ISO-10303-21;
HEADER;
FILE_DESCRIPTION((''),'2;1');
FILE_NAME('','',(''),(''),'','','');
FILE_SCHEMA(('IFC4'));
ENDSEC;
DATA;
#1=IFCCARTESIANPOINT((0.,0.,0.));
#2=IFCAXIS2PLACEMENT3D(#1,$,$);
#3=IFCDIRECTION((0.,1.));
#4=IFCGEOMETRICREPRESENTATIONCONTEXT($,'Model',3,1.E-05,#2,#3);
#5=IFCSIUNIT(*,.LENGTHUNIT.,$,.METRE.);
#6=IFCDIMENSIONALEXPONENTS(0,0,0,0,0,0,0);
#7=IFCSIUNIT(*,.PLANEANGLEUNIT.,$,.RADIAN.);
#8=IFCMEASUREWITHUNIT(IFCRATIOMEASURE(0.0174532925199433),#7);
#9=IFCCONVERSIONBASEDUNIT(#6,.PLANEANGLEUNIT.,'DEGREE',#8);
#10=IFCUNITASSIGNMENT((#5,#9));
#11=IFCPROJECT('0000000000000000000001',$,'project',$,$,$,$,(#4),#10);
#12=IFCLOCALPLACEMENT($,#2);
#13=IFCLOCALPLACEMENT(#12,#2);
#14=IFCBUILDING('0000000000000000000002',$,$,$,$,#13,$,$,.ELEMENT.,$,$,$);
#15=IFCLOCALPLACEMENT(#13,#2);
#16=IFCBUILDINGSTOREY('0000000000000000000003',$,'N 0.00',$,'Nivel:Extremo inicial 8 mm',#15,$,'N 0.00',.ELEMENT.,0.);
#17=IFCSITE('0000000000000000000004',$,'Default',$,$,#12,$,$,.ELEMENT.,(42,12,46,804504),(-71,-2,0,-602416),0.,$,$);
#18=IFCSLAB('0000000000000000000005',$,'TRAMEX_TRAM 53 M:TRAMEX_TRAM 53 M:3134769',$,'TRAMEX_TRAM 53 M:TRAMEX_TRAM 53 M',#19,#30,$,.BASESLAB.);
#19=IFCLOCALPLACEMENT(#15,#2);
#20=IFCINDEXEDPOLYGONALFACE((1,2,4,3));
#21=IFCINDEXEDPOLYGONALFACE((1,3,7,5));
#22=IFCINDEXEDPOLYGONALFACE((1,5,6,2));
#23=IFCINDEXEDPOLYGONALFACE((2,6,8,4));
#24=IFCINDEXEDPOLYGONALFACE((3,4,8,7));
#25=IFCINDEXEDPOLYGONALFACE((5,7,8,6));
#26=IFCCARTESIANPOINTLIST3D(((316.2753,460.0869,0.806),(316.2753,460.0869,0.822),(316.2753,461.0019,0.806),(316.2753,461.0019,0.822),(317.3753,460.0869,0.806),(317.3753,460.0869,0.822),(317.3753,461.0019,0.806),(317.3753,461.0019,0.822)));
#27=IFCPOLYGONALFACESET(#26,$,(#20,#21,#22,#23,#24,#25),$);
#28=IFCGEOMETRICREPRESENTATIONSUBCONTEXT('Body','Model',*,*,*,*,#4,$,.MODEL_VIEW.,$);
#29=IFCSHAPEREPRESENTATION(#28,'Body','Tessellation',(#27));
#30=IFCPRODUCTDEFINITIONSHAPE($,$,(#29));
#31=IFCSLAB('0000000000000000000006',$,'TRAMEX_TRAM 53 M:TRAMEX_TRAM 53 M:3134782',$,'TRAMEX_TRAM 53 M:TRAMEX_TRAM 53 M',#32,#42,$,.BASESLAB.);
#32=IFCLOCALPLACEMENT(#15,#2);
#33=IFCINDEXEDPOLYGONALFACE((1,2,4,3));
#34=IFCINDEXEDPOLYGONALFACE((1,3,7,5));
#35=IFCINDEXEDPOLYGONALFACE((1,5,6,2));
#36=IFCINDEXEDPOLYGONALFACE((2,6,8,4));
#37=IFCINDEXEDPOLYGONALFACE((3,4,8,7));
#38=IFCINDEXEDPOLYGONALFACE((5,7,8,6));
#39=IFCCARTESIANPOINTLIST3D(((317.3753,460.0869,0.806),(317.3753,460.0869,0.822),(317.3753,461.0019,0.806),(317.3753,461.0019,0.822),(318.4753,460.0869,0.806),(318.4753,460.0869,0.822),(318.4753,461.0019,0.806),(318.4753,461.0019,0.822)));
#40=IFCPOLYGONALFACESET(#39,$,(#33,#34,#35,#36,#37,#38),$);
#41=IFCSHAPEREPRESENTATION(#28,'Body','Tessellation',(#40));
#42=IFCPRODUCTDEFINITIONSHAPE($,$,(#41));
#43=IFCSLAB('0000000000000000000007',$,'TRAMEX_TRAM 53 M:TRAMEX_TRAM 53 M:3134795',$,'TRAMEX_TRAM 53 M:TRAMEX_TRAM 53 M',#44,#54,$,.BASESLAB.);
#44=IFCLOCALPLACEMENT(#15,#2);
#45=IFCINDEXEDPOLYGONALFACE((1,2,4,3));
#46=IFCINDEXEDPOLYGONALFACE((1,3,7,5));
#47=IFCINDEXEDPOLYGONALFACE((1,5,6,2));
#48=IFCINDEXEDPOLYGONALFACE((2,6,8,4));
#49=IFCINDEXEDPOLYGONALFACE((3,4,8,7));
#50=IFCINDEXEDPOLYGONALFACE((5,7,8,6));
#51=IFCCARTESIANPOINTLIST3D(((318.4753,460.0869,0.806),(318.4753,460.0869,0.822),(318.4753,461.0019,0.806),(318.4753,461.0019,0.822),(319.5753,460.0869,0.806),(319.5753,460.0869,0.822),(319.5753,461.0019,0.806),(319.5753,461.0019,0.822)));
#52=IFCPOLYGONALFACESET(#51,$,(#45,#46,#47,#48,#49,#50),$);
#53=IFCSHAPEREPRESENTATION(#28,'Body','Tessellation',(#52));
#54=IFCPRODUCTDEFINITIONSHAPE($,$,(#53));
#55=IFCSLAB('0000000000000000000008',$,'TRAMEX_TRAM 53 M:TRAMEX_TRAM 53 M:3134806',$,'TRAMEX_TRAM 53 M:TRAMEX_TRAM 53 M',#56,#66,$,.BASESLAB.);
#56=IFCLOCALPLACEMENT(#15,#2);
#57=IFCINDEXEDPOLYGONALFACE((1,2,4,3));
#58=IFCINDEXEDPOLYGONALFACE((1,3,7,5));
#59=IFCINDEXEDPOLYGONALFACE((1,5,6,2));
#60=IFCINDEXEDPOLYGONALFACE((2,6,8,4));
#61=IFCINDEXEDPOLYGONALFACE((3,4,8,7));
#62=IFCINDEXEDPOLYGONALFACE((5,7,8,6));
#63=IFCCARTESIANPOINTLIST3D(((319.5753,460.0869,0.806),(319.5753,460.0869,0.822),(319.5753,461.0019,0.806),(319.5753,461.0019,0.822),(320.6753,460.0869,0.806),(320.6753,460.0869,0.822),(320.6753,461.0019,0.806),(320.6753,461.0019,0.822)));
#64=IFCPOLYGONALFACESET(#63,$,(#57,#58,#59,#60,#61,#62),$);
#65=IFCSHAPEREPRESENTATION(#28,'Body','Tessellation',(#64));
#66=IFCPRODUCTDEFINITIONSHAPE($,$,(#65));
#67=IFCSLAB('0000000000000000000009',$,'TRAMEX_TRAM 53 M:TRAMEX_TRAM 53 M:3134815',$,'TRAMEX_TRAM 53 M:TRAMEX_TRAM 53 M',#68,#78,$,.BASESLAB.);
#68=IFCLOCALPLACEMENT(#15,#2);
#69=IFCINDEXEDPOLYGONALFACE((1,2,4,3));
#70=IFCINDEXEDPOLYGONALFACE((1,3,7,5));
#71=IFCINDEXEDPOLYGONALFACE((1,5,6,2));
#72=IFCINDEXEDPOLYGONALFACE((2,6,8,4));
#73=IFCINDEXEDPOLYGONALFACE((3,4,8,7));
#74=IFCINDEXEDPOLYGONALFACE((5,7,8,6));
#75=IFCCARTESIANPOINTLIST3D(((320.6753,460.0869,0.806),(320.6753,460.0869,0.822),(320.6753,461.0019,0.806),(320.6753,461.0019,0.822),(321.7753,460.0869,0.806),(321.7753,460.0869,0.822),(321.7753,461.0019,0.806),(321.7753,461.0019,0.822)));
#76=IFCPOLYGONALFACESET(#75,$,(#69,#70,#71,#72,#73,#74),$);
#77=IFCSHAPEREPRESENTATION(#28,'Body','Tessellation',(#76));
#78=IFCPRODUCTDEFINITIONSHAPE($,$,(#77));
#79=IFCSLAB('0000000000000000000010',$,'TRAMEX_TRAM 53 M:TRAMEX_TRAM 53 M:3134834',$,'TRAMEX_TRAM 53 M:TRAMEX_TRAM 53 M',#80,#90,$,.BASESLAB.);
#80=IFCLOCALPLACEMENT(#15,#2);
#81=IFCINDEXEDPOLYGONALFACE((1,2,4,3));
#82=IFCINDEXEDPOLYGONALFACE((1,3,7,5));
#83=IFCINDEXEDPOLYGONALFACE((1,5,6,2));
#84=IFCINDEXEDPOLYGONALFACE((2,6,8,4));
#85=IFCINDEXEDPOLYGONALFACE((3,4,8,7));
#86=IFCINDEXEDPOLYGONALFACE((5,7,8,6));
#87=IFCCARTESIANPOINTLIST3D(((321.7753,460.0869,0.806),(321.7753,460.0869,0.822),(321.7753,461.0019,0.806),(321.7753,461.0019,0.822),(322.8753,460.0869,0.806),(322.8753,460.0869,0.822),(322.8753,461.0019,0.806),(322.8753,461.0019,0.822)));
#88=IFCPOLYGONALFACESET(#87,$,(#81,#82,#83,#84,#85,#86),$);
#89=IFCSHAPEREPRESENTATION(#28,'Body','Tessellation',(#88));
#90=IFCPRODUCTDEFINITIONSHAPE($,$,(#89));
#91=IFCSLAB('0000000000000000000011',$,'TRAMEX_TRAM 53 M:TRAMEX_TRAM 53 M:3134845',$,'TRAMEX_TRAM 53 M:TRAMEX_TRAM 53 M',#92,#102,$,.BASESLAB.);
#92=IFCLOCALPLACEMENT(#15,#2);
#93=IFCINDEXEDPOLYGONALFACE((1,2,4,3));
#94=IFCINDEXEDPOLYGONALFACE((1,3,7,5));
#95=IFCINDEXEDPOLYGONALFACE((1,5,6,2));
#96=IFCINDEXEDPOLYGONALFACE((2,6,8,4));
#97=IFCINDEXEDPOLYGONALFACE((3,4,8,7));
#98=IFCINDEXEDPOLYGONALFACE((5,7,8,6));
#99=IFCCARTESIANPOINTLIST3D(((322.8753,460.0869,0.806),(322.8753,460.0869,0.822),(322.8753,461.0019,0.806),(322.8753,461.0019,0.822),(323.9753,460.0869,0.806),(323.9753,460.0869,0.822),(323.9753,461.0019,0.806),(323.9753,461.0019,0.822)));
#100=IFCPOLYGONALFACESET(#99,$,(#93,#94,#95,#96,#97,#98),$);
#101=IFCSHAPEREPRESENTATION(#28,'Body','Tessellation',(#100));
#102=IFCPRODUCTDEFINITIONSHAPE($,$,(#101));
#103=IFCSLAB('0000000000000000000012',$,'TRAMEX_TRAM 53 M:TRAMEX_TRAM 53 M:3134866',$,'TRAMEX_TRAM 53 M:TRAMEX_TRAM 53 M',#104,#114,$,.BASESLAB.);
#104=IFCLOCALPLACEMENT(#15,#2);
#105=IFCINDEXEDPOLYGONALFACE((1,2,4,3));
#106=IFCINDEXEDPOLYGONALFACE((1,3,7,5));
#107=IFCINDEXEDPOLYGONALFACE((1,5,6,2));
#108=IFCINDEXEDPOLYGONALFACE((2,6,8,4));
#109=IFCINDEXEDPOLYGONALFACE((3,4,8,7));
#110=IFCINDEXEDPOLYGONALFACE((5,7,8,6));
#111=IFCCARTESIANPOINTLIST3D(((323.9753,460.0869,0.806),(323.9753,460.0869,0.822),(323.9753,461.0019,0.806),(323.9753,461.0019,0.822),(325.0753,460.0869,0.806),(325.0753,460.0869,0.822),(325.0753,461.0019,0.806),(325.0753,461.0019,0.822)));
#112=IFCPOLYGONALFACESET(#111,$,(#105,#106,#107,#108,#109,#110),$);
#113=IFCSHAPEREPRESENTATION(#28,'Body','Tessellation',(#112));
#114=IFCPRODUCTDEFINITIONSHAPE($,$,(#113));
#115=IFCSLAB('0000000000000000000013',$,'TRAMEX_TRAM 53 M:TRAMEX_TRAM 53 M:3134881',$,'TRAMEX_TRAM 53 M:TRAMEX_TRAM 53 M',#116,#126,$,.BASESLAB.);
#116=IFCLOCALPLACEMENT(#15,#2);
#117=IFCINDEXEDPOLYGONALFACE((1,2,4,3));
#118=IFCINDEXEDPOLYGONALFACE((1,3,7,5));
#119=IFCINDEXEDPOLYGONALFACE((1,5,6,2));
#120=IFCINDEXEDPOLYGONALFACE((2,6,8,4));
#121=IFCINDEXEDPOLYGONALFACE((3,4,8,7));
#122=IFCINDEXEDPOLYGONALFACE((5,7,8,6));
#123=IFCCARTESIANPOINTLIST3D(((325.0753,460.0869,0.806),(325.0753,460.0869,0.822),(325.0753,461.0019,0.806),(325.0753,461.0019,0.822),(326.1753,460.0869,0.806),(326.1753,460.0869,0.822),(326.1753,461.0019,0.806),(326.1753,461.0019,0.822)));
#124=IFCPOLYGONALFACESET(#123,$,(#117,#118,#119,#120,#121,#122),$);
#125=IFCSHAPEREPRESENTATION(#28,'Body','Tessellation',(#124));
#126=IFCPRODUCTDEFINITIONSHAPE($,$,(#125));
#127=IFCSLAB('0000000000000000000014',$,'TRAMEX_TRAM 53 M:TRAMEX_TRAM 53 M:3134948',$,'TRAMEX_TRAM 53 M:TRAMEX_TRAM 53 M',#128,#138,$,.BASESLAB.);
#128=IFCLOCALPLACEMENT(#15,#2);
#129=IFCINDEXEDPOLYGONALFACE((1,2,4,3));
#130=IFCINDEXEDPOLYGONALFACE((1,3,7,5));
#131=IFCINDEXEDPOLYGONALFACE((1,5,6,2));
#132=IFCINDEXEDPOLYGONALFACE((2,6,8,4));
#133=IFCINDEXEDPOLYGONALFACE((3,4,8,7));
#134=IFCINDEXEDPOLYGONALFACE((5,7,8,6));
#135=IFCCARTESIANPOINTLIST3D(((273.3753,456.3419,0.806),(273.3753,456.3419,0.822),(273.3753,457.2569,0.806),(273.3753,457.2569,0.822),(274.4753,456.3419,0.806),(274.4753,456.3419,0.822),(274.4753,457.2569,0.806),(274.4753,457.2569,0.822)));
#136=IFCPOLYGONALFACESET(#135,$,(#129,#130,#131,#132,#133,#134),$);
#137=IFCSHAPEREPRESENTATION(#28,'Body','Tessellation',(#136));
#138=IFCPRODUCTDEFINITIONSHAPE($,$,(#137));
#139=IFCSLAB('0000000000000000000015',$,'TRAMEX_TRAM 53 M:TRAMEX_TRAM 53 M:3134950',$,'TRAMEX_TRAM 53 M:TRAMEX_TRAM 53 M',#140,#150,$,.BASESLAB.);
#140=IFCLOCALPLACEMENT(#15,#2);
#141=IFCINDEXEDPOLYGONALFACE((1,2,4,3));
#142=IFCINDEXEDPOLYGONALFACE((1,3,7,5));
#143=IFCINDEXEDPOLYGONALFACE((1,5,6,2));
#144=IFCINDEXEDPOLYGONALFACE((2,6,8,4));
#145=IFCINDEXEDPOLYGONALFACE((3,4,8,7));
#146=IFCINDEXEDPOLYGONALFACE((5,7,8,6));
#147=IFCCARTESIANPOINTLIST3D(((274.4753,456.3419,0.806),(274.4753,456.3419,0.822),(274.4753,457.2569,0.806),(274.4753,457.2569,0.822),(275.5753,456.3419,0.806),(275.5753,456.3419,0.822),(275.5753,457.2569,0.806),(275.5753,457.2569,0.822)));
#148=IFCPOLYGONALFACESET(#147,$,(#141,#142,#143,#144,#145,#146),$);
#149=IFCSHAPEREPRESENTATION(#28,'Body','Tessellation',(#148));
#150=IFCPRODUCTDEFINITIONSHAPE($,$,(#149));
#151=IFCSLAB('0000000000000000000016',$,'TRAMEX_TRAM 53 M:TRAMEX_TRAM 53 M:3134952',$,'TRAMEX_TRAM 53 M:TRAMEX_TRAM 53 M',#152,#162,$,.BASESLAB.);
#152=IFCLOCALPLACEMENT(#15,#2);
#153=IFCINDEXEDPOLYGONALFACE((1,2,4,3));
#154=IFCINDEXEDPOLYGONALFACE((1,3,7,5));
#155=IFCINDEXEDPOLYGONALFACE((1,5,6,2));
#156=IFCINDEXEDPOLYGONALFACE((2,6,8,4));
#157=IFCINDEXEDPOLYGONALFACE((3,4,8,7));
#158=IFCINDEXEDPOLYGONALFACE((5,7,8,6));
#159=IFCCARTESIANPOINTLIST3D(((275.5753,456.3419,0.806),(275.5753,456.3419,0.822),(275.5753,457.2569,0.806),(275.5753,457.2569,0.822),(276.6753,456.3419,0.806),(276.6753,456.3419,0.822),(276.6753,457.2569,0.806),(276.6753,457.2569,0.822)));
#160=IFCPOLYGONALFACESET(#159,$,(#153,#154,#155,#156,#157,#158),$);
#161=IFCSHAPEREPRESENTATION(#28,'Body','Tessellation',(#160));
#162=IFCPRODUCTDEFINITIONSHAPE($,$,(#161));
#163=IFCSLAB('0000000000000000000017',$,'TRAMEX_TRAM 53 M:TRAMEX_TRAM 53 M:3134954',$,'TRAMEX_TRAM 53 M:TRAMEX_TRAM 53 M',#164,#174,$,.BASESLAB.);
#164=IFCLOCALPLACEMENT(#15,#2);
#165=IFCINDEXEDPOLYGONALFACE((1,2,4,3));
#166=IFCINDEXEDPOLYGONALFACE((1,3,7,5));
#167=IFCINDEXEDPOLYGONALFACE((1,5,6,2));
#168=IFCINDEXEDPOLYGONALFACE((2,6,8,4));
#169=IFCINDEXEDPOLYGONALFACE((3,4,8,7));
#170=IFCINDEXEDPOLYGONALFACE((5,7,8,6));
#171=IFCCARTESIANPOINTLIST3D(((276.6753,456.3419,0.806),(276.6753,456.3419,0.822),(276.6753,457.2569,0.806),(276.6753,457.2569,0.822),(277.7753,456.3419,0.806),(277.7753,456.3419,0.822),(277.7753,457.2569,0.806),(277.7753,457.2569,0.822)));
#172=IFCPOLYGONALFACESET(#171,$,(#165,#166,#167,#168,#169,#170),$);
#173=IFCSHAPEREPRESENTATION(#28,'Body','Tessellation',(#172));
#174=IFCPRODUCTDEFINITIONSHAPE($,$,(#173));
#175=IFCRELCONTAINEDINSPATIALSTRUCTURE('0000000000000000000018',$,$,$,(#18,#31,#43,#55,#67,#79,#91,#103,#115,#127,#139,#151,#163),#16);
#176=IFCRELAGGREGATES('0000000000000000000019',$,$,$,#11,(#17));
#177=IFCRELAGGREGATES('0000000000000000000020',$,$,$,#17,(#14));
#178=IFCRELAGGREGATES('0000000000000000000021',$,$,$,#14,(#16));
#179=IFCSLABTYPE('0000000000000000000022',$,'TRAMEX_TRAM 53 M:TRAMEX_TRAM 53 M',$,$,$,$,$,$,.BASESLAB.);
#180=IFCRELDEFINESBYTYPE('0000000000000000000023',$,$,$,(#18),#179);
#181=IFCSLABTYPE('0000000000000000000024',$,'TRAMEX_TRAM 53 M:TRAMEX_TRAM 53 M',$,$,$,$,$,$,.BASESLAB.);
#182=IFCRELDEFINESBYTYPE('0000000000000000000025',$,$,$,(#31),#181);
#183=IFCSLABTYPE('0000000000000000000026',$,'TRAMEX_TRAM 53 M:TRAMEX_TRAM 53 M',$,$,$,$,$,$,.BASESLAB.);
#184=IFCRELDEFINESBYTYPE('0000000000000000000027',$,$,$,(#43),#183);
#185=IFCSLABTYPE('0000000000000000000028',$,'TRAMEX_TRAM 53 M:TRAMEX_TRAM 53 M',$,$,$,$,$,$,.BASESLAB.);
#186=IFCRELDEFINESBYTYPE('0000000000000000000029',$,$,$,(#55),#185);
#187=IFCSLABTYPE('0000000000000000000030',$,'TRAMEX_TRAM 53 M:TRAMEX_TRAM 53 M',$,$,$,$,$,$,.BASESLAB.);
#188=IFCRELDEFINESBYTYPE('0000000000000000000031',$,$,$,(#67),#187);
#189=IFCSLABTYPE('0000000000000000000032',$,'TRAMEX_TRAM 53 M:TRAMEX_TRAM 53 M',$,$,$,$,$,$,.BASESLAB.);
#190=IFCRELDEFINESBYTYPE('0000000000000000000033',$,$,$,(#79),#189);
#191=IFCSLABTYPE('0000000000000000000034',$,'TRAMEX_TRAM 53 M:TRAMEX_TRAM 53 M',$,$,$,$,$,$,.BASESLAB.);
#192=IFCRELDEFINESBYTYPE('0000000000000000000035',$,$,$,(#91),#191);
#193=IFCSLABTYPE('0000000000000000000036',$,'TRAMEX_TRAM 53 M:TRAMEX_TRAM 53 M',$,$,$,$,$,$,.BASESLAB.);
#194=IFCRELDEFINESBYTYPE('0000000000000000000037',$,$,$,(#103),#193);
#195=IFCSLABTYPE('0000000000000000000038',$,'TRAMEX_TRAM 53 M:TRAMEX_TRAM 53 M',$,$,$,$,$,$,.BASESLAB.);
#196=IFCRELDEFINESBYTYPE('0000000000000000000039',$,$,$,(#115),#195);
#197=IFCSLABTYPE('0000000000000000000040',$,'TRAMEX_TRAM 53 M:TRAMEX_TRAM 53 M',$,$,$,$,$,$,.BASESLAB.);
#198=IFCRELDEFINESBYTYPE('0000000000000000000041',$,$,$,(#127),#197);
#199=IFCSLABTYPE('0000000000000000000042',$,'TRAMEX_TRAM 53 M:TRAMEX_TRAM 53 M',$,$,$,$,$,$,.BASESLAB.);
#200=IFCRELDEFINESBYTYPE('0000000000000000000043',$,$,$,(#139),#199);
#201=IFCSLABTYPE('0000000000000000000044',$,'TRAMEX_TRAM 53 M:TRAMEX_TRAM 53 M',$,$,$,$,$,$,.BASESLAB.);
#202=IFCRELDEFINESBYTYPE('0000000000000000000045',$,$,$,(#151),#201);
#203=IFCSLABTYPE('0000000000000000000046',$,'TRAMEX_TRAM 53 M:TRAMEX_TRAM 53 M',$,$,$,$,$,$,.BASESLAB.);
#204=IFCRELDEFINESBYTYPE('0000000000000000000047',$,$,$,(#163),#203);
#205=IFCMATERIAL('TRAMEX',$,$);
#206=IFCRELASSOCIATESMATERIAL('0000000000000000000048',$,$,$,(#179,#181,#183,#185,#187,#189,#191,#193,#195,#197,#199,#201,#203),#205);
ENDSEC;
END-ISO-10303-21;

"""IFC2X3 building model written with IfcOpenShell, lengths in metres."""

from ifc_helpers import new_model, entity, si_unit, converted_unit, direction, frame, frame_2d, origin, place, context, subcontext, project, spatial, rectangle, extrude, material, type_object, element, save


model = new_model("IFC2X3")

# Units and contexts
model_context = context("Model", 3, precision=1e-05, world=origin(), true_north=direction((0.0, 1.0)))
body_context = subcontext(model_context, "Body", "Model", "MODEL_VIEW")
ifc_project = project(units=[si_unit("LENGTHUNIT", "METRE"), converted_unit("PLANEANGLEUNIT", "DEGREE", entity("IfcRatioMeasure", 0.0174532925199433), si_unit("PLANEANGLEUNIT", "RADIAN"), dimensions=[0, 0, 0, 0, 0, 0, 0])], contexts=[model_context])

# Site, building, storey
site_placement = place(None, origin())
site = spatial("IfcSite", under=ifc_project, at=site_placement, Name="Default", CompositionType="ELEMENT", RefLatitude=(42, 12, 46, 804504), RefLongitude=(-71, -2, 0, -602416), RefElevation=0.0)
building_placement = place(site_placement, origin())
building = spatial("IfcBuilding", under=site, at=building_placement, CompositionType="ELEMENT")
storey_placement = place(building_placement, origin())
storey = spatial("IfcBuildingStorey", under=building, at=storey_placement, Name="N 0.00", ObjectType="Nivel:Extremo inicial 8 mm", LongName="N 0.00", CompositionType="ELEMENT", Elevation=0.0)

# Slabs
ifc_material = material(Name="TRAMEX")
slab_type_1 = type_object("IfcSlabType", Name="TRAMEX_TRAM 53 M:TRAMEX_TRAM 53 M", PredefinedType="BASESLAB", material=ifc_material)
slab_1_placement = place(storey_placement, origin())
element("IfcSlab", 1, at=slab_1_placement, inside=storey, type_object=slab_type_1, Name="TRAMEX_TRAM 53 M:TRAMEX_TRAM 53 M:3134769", ObjectType="TRAMEX_TRAM 53 M:TRAMEX_TRAM 53 M", PredefinedType="BASESLAB", context=body_context, shape_type="SweptSolid", body=[
    extrude(rectangle(XDim=0.915, YDim=1.1, at=frame_2d((0.0, 0.0), x_axis=(1.0, 0.0))), frame((316.8253, 460.5444, 0.806), z_axis=(0.0, 0.0, 1.0), x_axis=(0.0, 1.0, 0.0)), (0.0, 0.0, 1.0), 0.016),
])
slab_type_2 = type_object("IfcSlabType", Name="TRAMEX_TRAM 53 M:TRAMEX_TRAM 53 M", PredefinedType="BASESLAB", material=ifc_material)
slab_2_placement = place(storey_placement, origin())
element("IfcSlab", 2, at=slab_2_placement, inside=storey, type_object=slab_type_2, Name="TRAMEX_TRAM 53 M:TRAMEX_TRAM 53 M:3134782", ObjectType="TRAMEX_TRAM 53 M:TRAMEX_TRAM 53 M", PredefinedType="BASESLAB", context=body_context, shape_type="SweptSolid", body=[
    extrude(rectangle(XDim=0.915, YDim=1.1, at=frame_2d((0.0, 0.0), x_axis=(1.0, 0.0))), frame((317.9253, 460.5444, 0.806), z_axis=(0.0, 0.0, 1.0), x_axis=(0.0, 1.0, 0.0)), (0.0, 0.0, 1.0), 0.016),
])
slab_type_3 = type_object("IfcSlabType", Name="TRAMEX_TRAM 53 M:TRAMEX_TRAM 53 M", PredefinedType="BASESLAB", material=ifc_material)
slab_3_placement = place(storey_placement, origin())
element("IfcSlab", 3, at=slab_3_placement, inside=storey, type_object=slab_type_3, Name="TRAMEX_TRAM 53 M:TRAMEX_TRAM 53 M:3134795", ObjectType="TRAMEX_TRAM 53 M:TRAMEX_TRAM 53 M", PredefinedType="BASESLAB", context=body_context, shape_type="SweptSolid", body=[
    extrude(rectangle(XDim=0.915, YDim=1.1, at=frame_2d((0.0, 0.0), x_axis=(1.0, 0.0))), frame((319.0253, 460.5444, 0.806), z_axis=(0.0, 0.0, 1.0), x_axis=(0.0, 1.0, 0.0)), (0.0, 0.0, 1.0), 0.016),
])
slab_type_4 = type_object("IfcSlabType", Name="TRAMEX_TRAM 53 M:TRAMEX_TRAM 53 M", PredefinedType="BASESLAB", material=ifc_material)
slab_4_placement = place(storey_placement, origin())
element("IfcSlab", 4, at=slab_4_placement, inside=storey, type_object=slab_type_4, Name="TRAMEX_TRAM 53 M:TRAMEX_TRAM 53 M:3134806", ObjectType="TRAMEX_TRAM 53 M:TRAMEX_TRAM 53 M", PredefinedType="BASESLAB", context=body_context, shape_type="SweptSolid", body=[
    extrude(rectangle(XDim=0.915, YDim=1.1, at=frame_2d((0.0, 0.0), x_axis=(1.0, 0.0))), frame((320.1253, 460.5444, 0.806), z_axis=(0.0, 0.0, 1.0), x_axis=(0.0, 1.0, 0.0)), (0.0, 0.0, 1.0), 0.016),
])
slab_type_5 = type_object("IfcSlabType", Name="TRAMEX_TRAM 53 M:TRAMEX_TRAM 53 M", PredefinedType="BASESLAB", material=ifc_material)
slab_5_placement = place(storey_placement, origin())
element("IfcSlab", 5, at=slab_5_placement, inside=storey, type_object=slab_type_5, Name="TRAMEX_TRAM 53 M:TRAMEX_TRAM 53 M:3134815", ObjectType="TRAMEX_TRAM 53 M:TRAMEX_TRAM 53 M", PredefinedType="BASESLAB", context=body_context, shape_type="SweptSolid", body=[
    extrude(rectangle(XDim=0.915, YDim=1.1, at=frame_2d((0.0, 0.0), x_axis=(1.0, 0.0))), frame((321.2253, 460.5444, 0.806), z_axis=(0.0, 0.0, 1.0), x_axis=(0.0, 1.0, 0.0)), (0.0, 0.0, 1.0), 0.016),
])
slab_type_6 = type_object("IfcSlabType", Name="TRAMEX_TRAM 53 M:TRAMEX_TRAM 53 M", PredefinedType="BASESLAB", material=ifc_material)
slab_6_placement = place(storey_placement, origin())
element("IfcSlab", 6, at=slab_6_placement, inside=storey, type_object=slab_type_6, Name="TRAMEX_TRAM 53 M:TRAMEX_TRAM 53 M:3134834", ObjectType="TRAMEX_TRAM 53 M:TRAMEX_TRAM 53 M", PredefinedType="BASESLAB", context=body_context, shape_type="SweptSolid", body=[
    extrude(rectangle(XDim=0.915, YDim=1.1, at=frame_2d((0.0, 0.0), x_axis=(1.0, 0.0))), frame((322.3253, 460.5444, 0.806), z_axis=(0.0, 0.0, 1.0), x_axis=(0.0, 1.0, 0.0)), (0.0, 0.0, 1.0), 0.016),
])
slab_type_7 = type_object("IfcSlabType", Name="TRAMEX_TRAM 53 M:TRAMEX_TRAM 53 M", PredefinedType="BASESLAB", material=ifc_material)
slab_7_placement = place(storey_placement, origin())
element("IfcSlab", 7, at=slab_7_placement, inside=storey, type_object=slab_type_7, Name="TRAMEX_TRAM 53 M:TRAMEX_TRAM 53 M:3134845", ObjectType="TRAMEX_TRAM 53 M:TRAMEX_TRAM 53 M", PredefinedType="BASESLAB", context=body_context, shape_type="SweptSolid", body=[
    extrude(rectangle(XDim=0.915, YDim=1.1, at=frame_2d((0.0, 0.0), x_axis=(1.0, 0.0))), frame((323.4253, 460.5444, 0.806), z_axis=(0.0, 0.0, 1.0), x_axis=(0.0, 1.0, 0.0)), (0.0, 0.0, 1.0), 0.016),
])
slab_type_8 = type_object("IfcSlabType", Name="TRAMEX_TRAM 53 M:TRAMEX_TRAM 53 M", PredefinedType="BASESLAB", material=ifc_material)
slab_8_placement = place(storey_placement, origin())
element("IfcSlab", 8, at=slab_8_placement, inside=storey, type_object=slab_type_8, Name="TRAMEX_TRAM 53 M:TRAMEX_TRAM 53 M:3134866", ObjectType="TRAMEX_TRAM 53 M:TRAMEX_TRAM 53 M", PredefinedType="BASESLAB", context=body_context, shape_type="SweptSolid", body=[
    extrude(rectangle(XDim=0.915, YDim=1.1, at=frame_2d((0.0, 0.0), x_axis=(1.0, 0.0))), frame((324.5253, 460.5444, 0.806), z_axis=(0.0, 0.0, 1.0), x_axis=(0.0, 1.0, 0.0)), (0.0, 0.0, 1.0), 0.016),
])
slab_type_9 = type_object("IfcSlabType", Name="TRAMEX_TRAM 53 M:TRAMEX_TRAM 53 M", PredefinedType="BASESLAB", material=ifc_material)
slab_9_placement = place(storey_placement, origin())
element("IfcSlab", 9, at=slab_9_placement, inside=storey, type_object=slab_type_9, Name="TRAMEX_TRAM 53 M:TRAMEX_TRAM 53 M:3134881", ObjectType="TRAMEX_TRAM 53 M:TRAMEX_TRAM 53 M", PredefinedType="BASESLAB", context=body_context, shape_type="SweptSolid", body=[
    extrude(rectangle(XDim=0.915, YDim=1.1, at=frame_2d((0.0, 0.0), x_axis=(1.0, 0.0))), frame((325.6253, 460.5444, 0.806), z_axis=(0.0, 0.0, 1.0), x_axis=(0.0, 1.0, 0.0)), (0.0, 0.0, 1.0), 0.016),
])
slab_type_10 = type_object("IfcSlabType", Name="TRAMEX_TRAM 53 M:TRAMEX_TRAM 53 M", PredefinedType="BASESLAB", material=ifc_material)
slab_10_placement = place(storey_placement, origin())
element("IfcSlab", 10, at=slab_10_placement, inside=storey, type_object=slab_type_10, Name="TRAMEX_TRAM 53 M:TRAMEX_TRAM 53 M:3134948", ObjectType="TRAMEX_TRAM 53 M:TRAMEX_TRAM 53 M", PredefinedType="BASESLAB", context=body_context, shape_type="SweptSolid", body=[
    extrude(rectangle(XDim=1.1, YDim=0.915, at=frame_2d((0.0, 0.0), x_axis=(1.0, 0.0))), frame((273.9253, 456.7994, 0.806), z_axis=(0.0, 0.0, 1.0), x_axis=(-1.0, 0.0, 0.0)), (0.0, 0.0, 1.0), 0.016),
])
slab_type_11 = type_object("IfcSlabType", Name="TRAMEX_TRAM 53 M:TRAMEX_TRAM 53 M", PredefinedType="BASESLAB", material=ifc_material)
slab_11_placement = place(storey_placement, origin())
element("IfcSlab", 11, at=slab_11_placement, inside=storey, type_object=slab_type_11, Name="TRAMEX_TRAM 53 M:TRAMEX_TRAM 53 M:3134950", ObjectType="TRAMEX_TRAM 53 M:TRAMEX_TRAM 53 M", PredefinedType="BASESLAB", context=body_context, shape_type="SweptSolid", body=[
    extrude(rectangle(XDim=1.1, YDim=0.915, at=frame_2d((0.0, 0.0), x_axis=(1.0, 0.0))), frame((275.0253, 456.7994, 0.806), z_axis=(0.0, 0.0, 1.0), x_axis=(-1.0, 0.0, 0.0)), (0.0, 0.0, 1.0), 0.016),
])
slab_type_12 = type_object("IfcSlabType", Name="TRAMEX_TRAM 53 M:TRAMEX_TRAM 53 M", PredefinedType="BASESLAB", material=ifc_material)
slab_12_placement = place(storey_placement, origin())
element("IfcSlab", 12, at=slab_12_placement, inside=storey, type_object=slab_type_12, Name="TRAMEX_TRAM 53 M:TRAMEX_TRAM 53 M:3134952", ObjectType="TRAMEX_TRAM 53 M:TRAMEX_TRAM 53 M", PredefinedType="BASESLAB", context=body_context, shape_type="SweptSolid", body=[
    extrude(rectangle(XDim=1.1, YDim=0.915, at=frame_2d((0.0, 0.0), x_axis=(1.0, 0.0))), frame((276.1253, 456.7994, 0.806), z_axis=(0.0, 0.0, 1.0), x_axis=(-1.0, 0.0, 0.0)), (0.0, 0.0, 1.0), 0.016),
])
slab_type_13 = type_object("IfcSlabType", Name="TRAMEX_TRAM 53 M:TRAMEX_TRAM 53 M", PredefinedType="BASESLAB", material=ifc_material)
slab_13_placement = place(storey_placement, origin())
element("IfcSlab", 13, at=slab_13_placement, inside=storey, type_object=slab_type_13, Name="TRAMEX_TRAM 53 M:TRAMEX_TRAM 53 M:3134954", ObjectType="TRAMEX_TRAM 53 M:TRAMEX_TRAM 53 M", PredefinedType="BASESLAB", context=body_context, shape_type="SweptSolid", body=[
    extrude(rectangle(XDim=1.1, YDim=0.915, at=frame_2d((0.0, 0.0), x_axis=(1.0, 0.0))), frame((277.2253, 456.7994, 0.806), z_axis=(0.0, 0.0, 1.0), x_axis=(-1.0, 0.0, 0.0)), (0.0, 0.0, 1.0), 0.016),
])

save(model, "model.ifc")
